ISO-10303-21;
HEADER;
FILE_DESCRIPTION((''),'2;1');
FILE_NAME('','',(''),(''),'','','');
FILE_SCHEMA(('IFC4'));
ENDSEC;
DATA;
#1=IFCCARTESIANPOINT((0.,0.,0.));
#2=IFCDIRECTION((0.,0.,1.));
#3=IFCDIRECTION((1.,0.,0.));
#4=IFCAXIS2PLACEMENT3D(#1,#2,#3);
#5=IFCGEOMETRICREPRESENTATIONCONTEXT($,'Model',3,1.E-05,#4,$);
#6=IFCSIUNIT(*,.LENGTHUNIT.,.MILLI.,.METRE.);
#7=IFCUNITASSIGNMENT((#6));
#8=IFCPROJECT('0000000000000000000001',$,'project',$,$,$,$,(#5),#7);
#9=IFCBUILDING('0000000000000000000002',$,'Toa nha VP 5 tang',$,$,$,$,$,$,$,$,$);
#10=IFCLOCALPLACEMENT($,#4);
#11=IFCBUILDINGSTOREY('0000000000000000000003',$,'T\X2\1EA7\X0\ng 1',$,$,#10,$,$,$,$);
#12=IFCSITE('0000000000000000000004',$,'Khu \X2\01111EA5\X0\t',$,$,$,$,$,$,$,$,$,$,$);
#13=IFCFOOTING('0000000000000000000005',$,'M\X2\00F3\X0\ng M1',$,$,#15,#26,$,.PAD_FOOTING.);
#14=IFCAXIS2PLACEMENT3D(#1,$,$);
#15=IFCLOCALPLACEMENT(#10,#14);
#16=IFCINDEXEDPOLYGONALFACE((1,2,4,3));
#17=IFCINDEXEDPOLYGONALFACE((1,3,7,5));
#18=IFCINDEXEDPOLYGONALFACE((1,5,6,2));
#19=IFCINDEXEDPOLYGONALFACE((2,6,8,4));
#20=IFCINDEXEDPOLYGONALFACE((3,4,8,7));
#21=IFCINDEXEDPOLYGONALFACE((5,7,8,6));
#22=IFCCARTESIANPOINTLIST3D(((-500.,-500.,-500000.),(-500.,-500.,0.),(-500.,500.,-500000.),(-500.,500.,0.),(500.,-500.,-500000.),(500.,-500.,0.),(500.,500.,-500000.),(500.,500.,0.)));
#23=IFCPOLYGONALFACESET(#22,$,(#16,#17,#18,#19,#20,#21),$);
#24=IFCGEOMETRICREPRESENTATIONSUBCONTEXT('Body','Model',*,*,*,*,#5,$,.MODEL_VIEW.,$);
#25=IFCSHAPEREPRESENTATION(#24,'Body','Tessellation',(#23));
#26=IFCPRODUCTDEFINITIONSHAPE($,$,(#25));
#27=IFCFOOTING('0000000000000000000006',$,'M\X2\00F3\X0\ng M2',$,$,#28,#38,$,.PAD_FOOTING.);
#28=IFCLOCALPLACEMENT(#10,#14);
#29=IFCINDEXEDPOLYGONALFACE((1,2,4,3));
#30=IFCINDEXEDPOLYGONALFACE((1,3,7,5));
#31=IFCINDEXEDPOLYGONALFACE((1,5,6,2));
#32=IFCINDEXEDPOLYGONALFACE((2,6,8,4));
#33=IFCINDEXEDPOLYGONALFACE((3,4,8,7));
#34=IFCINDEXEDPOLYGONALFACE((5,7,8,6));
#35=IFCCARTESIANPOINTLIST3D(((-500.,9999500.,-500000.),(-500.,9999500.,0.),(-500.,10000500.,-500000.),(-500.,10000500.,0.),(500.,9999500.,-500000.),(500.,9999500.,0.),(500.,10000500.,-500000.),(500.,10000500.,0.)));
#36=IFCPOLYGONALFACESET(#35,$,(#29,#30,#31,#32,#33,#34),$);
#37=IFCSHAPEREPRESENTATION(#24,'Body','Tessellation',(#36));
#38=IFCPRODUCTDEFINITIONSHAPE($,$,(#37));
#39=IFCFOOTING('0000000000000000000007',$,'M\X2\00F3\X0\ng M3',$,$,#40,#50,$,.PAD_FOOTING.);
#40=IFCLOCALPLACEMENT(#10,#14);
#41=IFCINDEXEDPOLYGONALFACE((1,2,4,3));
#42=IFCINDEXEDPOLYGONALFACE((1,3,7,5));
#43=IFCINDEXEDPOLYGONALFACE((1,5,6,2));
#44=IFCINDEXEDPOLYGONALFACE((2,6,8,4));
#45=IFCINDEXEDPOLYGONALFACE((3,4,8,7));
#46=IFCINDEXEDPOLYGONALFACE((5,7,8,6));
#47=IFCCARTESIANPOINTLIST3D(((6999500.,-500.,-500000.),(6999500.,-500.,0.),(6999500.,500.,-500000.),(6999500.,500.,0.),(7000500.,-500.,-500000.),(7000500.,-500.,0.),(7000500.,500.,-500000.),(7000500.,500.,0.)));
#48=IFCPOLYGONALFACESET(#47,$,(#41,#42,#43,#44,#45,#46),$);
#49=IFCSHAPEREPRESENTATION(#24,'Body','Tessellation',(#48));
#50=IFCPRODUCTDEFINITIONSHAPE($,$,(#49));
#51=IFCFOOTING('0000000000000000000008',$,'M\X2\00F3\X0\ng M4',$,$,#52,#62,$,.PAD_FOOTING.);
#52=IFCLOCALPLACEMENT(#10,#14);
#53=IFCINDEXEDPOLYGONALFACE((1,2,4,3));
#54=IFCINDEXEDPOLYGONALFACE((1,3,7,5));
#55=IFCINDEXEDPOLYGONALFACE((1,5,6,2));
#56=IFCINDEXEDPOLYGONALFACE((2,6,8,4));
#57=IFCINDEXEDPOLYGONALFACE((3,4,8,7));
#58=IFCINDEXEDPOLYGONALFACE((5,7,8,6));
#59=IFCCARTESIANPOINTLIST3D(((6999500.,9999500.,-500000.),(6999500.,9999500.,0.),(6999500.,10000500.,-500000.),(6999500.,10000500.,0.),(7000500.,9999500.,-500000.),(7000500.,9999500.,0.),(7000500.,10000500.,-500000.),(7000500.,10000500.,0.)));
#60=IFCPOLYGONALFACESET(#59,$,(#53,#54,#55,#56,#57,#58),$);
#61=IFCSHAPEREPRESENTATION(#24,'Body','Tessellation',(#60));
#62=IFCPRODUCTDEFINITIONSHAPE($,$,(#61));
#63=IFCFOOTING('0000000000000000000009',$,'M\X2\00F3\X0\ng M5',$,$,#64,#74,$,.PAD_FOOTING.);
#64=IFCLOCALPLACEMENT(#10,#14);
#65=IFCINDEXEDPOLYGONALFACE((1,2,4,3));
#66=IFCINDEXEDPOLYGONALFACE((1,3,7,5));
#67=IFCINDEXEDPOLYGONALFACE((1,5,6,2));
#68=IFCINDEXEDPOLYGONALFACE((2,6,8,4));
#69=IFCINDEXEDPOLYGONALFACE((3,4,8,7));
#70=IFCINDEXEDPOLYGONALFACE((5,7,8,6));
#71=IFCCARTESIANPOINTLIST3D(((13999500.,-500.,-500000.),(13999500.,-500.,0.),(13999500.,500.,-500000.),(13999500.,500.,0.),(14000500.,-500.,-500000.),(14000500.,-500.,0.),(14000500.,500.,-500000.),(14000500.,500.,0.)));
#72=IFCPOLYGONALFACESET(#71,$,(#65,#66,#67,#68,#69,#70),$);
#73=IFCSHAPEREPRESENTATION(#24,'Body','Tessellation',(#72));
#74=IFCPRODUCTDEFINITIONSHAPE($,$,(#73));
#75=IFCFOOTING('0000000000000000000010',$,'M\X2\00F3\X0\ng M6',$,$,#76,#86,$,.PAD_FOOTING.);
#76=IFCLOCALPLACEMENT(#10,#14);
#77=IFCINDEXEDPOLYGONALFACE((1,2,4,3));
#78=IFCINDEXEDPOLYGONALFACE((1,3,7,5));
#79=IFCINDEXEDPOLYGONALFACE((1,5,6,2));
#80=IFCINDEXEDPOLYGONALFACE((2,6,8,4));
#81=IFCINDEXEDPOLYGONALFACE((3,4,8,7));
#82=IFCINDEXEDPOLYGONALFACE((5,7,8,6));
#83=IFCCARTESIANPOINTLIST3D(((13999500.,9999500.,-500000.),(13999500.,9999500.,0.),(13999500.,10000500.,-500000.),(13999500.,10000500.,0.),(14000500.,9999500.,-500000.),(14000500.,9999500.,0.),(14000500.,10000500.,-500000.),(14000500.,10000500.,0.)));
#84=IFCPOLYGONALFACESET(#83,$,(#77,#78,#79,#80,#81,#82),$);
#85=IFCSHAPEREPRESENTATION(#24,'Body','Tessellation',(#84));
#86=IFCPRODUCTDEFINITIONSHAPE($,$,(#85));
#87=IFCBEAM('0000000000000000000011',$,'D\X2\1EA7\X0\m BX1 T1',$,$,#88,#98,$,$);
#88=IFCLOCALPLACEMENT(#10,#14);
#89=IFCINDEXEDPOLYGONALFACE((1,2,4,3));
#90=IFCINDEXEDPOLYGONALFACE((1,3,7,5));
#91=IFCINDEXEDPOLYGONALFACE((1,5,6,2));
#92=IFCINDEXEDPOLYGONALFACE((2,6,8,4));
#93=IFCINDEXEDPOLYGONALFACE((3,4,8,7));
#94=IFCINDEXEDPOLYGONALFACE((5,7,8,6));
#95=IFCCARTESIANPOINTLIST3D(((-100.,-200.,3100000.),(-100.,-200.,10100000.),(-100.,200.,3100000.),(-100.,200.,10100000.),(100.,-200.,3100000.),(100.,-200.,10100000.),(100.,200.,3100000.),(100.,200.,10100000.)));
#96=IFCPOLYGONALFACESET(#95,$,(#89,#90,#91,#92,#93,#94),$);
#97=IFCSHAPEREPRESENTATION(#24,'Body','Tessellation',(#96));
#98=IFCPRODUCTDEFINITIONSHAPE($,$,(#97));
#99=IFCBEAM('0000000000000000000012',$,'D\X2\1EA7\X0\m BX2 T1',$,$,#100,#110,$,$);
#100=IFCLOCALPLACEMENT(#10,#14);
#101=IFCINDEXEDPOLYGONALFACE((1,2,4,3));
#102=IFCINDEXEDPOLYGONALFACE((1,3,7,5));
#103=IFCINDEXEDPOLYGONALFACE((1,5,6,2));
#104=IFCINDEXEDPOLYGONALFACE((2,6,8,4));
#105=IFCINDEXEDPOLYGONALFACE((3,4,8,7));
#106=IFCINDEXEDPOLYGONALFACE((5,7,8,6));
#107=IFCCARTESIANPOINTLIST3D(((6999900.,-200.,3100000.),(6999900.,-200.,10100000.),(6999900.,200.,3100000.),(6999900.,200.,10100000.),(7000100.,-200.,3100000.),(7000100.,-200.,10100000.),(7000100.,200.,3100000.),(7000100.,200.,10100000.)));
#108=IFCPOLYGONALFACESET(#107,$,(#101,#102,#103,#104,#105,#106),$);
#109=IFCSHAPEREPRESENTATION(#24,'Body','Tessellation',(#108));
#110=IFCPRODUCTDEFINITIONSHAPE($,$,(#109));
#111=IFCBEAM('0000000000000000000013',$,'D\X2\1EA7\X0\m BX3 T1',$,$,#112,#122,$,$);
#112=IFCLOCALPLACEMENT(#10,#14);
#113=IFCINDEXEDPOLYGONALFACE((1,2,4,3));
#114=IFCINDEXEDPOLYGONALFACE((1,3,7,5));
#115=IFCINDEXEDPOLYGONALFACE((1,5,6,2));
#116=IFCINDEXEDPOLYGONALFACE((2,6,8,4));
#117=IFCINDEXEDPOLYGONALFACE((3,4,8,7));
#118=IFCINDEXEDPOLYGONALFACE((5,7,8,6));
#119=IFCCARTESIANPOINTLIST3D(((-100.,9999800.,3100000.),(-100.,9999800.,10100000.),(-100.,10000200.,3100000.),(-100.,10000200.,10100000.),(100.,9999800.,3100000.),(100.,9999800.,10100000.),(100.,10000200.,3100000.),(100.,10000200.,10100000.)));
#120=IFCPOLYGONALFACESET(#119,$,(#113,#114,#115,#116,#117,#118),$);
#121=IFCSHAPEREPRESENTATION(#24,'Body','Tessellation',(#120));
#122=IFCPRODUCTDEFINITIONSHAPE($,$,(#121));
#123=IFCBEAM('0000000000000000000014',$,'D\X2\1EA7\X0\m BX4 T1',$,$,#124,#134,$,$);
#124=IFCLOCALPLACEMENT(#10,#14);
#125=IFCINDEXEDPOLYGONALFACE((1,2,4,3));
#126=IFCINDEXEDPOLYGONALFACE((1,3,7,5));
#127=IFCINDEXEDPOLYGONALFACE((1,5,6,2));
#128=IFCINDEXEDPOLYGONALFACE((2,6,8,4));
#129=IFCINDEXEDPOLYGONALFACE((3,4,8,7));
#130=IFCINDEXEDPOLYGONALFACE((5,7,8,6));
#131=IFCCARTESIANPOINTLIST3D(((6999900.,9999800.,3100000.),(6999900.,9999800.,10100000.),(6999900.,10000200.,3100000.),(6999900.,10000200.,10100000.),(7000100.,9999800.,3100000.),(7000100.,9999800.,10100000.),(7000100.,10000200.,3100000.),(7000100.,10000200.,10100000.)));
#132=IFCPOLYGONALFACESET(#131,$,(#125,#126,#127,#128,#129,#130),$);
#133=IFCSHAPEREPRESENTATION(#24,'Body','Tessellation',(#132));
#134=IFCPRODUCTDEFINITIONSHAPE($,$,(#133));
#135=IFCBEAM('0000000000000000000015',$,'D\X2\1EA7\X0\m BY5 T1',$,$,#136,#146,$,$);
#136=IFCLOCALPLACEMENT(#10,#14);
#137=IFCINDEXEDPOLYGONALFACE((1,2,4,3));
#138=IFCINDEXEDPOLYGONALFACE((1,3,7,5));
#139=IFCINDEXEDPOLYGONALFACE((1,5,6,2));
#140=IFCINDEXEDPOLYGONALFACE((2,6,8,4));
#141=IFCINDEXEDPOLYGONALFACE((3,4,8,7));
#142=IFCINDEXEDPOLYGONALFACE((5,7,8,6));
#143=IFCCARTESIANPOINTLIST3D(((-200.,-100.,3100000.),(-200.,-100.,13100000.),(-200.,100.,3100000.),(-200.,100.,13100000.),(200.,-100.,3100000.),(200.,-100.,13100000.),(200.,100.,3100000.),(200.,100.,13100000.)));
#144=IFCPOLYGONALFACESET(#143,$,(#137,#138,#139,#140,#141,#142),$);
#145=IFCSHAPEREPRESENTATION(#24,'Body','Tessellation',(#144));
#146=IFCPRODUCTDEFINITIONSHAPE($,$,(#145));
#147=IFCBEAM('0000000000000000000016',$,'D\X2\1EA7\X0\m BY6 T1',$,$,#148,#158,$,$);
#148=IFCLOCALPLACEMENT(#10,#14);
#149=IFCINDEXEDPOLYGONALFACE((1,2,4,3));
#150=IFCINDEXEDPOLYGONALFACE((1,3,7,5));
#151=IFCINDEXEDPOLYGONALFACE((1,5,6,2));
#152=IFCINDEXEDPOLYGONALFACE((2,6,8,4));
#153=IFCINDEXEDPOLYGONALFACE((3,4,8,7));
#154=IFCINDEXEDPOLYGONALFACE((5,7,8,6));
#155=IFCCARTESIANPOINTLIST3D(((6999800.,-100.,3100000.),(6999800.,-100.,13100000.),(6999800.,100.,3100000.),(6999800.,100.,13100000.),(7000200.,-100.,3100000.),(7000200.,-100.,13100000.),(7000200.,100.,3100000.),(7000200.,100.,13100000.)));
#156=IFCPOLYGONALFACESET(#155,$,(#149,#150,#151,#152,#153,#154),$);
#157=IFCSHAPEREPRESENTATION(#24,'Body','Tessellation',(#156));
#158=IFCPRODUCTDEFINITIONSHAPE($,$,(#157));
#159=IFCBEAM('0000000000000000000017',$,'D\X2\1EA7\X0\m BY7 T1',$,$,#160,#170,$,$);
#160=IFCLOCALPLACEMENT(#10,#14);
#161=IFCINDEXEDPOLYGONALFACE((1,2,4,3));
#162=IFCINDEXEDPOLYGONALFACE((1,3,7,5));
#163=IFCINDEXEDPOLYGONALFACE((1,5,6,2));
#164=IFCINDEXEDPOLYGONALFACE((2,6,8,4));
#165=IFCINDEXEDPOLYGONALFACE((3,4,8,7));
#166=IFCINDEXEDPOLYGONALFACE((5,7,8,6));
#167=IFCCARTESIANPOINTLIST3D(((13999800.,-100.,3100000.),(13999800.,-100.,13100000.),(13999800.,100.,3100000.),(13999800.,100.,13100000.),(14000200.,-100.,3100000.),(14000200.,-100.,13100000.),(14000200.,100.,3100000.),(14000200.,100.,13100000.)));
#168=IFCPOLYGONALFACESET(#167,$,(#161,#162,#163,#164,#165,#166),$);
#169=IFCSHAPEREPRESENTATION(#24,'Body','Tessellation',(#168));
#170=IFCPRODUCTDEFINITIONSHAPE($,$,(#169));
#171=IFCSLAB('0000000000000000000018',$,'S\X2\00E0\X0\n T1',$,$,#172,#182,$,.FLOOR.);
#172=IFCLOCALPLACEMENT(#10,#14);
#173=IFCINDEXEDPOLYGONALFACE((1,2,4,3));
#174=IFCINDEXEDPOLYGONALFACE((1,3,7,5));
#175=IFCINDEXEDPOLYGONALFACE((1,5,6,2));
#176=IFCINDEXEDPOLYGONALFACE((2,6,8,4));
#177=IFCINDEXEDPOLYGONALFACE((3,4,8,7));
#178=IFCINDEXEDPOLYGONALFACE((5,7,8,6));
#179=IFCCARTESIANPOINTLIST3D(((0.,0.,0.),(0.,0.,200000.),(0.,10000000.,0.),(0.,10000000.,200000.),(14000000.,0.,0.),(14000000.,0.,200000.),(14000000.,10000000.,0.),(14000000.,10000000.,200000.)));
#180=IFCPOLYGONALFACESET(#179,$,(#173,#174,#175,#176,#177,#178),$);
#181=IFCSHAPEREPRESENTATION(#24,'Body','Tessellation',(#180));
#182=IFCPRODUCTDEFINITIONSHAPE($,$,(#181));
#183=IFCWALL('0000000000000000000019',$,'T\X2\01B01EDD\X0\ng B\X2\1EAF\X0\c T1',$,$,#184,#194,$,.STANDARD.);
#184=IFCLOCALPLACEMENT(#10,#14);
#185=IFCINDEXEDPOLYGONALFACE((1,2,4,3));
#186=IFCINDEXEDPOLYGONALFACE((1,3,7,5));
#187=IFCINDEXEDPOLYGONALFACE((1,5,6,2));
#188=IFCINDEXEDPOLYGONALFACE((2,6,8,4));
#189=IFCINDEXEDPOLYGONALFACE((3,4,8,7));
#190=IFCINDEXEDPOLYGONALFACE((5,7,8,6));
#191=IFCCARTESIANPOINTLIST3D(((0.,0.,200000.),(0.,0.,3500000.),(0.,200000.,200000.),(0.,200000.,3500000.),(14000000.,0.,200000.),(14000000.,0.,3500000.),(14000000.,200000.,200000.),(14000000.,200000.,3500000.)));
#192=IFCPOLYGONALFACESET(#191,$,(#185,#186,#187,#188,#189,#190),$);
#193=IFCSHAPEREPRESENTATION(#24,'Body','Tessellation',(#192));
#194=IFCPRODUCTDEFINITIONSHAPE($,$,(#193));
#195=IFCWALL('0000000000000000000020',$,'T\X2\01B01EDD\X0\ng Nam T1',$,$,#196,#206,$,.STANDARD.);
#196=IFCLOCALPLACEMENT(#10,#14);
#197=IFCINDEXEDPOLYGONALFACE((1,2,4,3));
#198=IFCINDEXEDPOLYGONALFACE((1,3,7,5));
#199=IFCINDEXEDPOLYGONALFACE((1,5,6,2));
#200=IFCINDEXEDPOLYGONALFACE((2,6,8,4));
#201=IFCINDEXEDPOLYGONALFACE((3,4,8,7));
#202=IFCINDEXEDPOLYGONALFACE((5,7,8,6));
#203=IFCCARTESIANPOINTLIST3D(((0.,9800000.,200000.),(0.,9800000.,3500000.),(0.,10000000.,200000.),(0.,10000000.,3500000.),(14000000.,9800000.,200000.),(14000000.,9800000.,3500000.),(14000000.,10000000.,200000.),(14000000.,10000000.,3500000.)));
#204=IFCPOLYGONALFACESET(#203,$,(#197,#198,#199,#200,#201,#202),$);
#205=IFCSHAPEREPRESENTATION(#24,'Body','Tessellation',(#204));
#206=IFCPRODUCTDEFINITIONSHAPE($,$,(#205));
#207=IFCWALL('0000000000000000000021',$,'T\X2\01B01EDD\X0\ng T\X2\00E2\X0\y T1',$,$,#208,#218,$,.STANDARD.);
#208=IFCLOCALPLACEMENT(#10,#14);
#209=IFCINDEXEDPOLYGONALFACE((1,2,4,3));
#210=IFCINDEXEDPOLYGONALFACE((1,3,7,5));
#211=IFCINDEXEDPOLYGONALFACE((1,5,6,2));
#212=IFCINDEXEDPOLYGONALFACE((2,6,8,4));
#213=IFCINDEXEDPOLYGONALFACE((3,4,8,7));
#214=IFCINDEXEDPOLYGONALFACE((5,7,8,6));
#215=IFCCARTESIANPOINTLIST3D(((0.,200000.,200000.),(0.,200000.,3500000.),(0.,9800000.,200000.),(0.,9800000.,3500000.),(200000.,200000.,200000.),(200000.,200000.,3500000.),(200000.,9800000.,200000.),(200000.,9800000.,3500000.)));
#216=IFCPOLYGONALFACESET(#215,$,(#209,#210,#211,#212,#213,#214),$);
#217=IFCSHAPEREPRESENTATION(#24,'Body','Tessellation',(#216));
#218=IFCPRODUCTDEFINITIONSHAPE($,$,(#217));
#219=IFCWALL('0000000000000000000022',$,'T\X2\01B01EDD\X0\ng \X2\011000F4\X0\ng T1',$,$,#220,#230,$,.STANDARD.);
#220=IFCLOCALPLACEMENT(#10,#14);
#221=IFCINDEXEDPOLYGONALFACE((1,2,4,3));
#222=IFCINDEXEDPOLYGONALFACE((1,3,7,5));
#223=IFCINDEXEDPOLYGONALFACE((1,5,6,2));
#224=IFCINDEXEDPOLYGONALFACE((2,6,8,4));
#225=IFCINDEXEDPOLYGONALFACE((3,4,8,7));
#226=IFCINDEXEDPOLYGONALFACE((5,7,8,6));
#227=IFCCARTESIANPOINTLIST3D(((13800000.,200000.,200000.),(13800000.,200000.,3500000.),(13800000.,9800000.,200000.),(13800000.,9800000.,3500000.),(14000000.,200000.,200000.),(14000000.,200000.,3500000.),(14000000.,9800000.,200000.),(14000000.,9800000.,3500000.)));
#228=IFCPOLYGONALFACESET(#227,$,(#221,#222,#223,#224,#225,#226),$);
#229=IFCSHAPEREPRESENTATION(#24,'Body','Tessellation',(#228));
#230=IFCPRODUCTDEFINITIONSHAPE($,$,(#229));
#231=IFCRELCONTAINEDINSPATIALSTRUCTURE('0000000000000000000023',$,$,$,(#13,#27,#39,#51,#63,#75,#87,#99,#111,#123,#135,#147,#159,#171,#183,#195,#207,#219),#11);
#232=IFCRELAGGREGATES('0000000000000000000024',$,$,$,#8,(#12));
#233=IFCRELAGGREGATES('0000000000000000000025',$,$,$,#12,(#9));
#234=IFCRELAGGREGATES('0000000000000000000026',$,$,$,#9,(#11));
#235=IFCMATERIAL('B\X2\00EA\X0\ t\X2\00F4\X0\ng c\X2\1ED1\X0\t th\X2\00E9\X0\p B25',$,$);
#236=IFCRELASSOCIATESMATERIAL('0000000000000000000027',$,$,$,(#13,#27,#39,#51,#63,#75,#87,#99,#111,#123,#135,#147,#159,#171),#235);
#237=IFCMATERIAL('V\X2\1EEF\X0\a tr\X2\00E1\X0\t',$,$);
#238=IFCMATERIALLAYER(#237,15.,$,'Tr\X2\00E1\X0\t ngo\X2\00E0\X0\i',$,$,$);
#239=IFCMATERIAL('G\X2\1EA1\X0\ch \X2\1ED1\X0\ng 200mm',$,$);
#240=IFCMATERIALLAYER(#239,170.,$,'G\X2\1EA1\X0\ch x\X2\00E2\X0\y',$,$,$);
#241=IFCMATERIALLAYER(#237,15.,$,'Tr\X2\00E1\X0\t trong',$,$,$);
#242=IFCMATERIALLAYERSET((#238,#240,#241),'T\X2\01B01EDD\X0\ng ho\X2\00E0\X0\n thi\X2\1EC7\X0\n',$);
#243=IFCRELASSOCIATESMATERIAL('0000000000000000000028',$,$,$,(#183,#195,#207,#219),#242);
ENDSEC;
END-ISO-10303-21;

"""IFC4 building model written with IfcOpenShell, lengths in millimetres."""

from ifc_helpers import new_model, entity, si_unit, frame, origin_with_axes, place, context, subcontext, project, spatial, indexed_curve, outline, extrude, material, layer, layer_set, layer_usage, element, save


model = new_model("IFC4")

# Units and contexts
model_context = context("Model", 3, precision=1e-05, world=origin_with_axes())
body_context = subcontext(model_context, "Body", "Model", "MODEL_VIEW")
ifc_project = project(units=[si_unit("LENGTHUNIT", "METRE", prefix="MILLI")], contexts=[model_context])

# Site, building, storey
site = spatial("IfcSite", under=ifc_project, Name="Khu đất")
building = spatial("IfcBuilding", under=site, Name="Toa nha VP 5 tang")
storey_placement = place(None, origin_with_axes())
storey = spatial("IfcBuildingStorey", under=building, at=storey_placement, Name="Tầng 1")

# Footings
ifc_material_1 = material(Name="Bê tông cốt thép B25")
for number, where, z_axis, x_axis, name in (
    (1, (0.0, 0.0, -500000.0), (0.0, 0.0, 1.0), (1.0, 0.0, 0.0), "Móng M1"),
    (2, (0.0, 10000000.0, -500000.0), (0.0, 0.0, 1.0), (1.0, 0.0, 0.0), "Móng M2"),
    (3, (7000000.0, 0.0, -500000.0), (0.0, 0.0, 1.0), (1.0, 0.0, 0.0), "Móng M3"),
    (4, (7000000.0, 10000000.0, -500000.0), (0.0, 0.0, 1.0), (1.0, 0.0, 0.0), "Móng M4"),
    (5, (14000000.0, 0.0, -500000.0), (0.0, 0.0, 1.0), (1.0, 0.0, 0.0), "Móng M5"),
    (6, (14000000.0, 10000000.0, -500000.0), (0.0, 0.0, 1.0), (1.0, 0.0, 0.0), "Móng M6"),
):
    element("IfcFooting", number, at=place(storey_placement, frame(where, z_axis=z_axis, x_axis=x_axis)), inside=storey, material=ifc_material_1, Name=name, PredefinedType="PAD_FOOTING", context=body_context, shape_type="SweptSolid", body=[
        extrude(entity("IfcRectangleProfileDef", None, None, None, 1000.0, 1000.0), origin_with_axes(), (0.0, 0.0, 1.0), 500000.0),
    ])

# Beams
for number, where, z_axis, x_axis, name in (
    (7, (0.0, 0.0, 3100000.0), (0.0, 0.0, 1.0), (1.0, 0.0, 0.0), "Dầm BX1 T1"),
    (8, (7000000.0, 0.0, 3100000.0), (0.0, 0.0, 1.0), (1.0, 0.0, 0.0), "Dầm BX2 T1"),
    (9, (0.0, 10000000.0, 3100000.0), (0.0, 0.0, 1.0), (1.0, 0.0, 0.0), "Dầm BX3 T1"),
    (10, (7000000.0, 10000000.0, 3100000.0), (0.0, 0.0, 1.0), (1.0, 0.0, 0.0), "Dầm BX4 T1"),
):
    element("IfcBeam", number, at=place(storey_placement, frame(where, z_axis=z_axis, x_axis=x_axis)), inside=storey, material=ifc_material_1, Name=name, context=body_context, shape_type="SweptSolid", body=[
        extrude(entity("IfcRectangleProfileDef", None, None, None, 200.0, 400.0), origin_with_axes(), (0.0, 0.0, 1.0), 7000000.0),
    ])
for number, where, z_axis, x_axis, name in (
    (11, (0.0, 0.0, 3100000.0), (0.0, 0.0, 1.0), (0.0, 1.0, 0.0), "Dầm BY5 T1"),
    (12, (7000000.0, 0.0, 3100000.0), (0.0, 0.0, 1.0), (0.0, 1.0, 0.0), "Dầm BY6 T1"),
    (13, (14000000.0, 0.0, 3100000.0), (0.0, 0.0, 1.0), (0.0, 1.0, 0.0), "Dầm BY7 T1"),
):
    element("IfcBeam", number, at=place(storey_placement, frame(where, z_axis=z_axis, x_axis=x_axis)), inside=storey, material=ifc_material_1, Name=name, context=body_context, shape_type="SweptSolid", body=[
        extrude(entity("IfcRectangleProfileDef", None, None, None, 200.0, 400.0), origin_with_axes(), (0.0, 0.0, 1.0), 10000000.0),
    ])

# Slab
slab_placement = place(storey_placement, origin_with_axes())
element("IfcSlab", 14, at=slab_placement, inside=storey, material=ifc_material_1, Name="Sàn T1", PredefinedType="FLOOR", context=body_context, shape_type="SweptSolid", body=[
    extrude(outline(indexed_curve([(0.0, 0.0), (14000000.0, 0.0), (14000000.0, 10000000.0), (0.0, 10000000.0), (0.0, 0.0)])), None, (0.0, 0.0, 1.0), 200000.0),
])

# Walls
ifc_material_2 = material(Name="Vữa trát")
ifc_layer_1 = layer(ifc_material_2, 15.0, Name="Trát ngoài")
ifc_material_3 = material(Name="Gạch ống 200mm")
ifc_layer_2 = layer(ifc_material_3, 170.0, Name="Gạch xây")
ifc_layer_3 = layer(ifc_material_2, 15.0, Name="Trát trong")
ifc_layer_set = layer_set([ifc_layer_1, ifc_layer_2, ifc_layer_3], Name="Tường hoàn thiện")
ifc_layer_usage_1 = layer_usage(ifc_layer_set, "AXIS2", "POSITIVE", 0.0)
wall_1_placement = place(storey_placement, frame((0.0, 0.0, 200000.0), z_axis=(0.0, 0.0, 1.0), x_axis=(1.0, 0.0, 0.0)))
element("IfcWall", 15, at=wall_1_placement, inside=storey, material=ifc_layer_usage_1, Name="Tường Bắc T1", PredefinedType="STANDARD", context=body_context, shape_type="SweptSolid", body=[
    extrude(outline(indexed_curve([(0.0, 0.0), (0.0, 200000.0), (14000000.0, 200000.0), (14000000.0, 0.0), (0.0, 0.0)], self_intersect=False)), origin_with_axes(), (0.0, 0.0, 1.0), 3300000.0),
])
ifc_layer_usage_2 = layer_usage(ifc_layer_set, "AXIS2", "POSITIVE", 0.0)
wall_2_placement = place(storey_placement, frame((0.0, 9800000.0, 200000.0), z_axis=(0.0, 0.0, 1.0), x_axis=(1.0, 0.0, 0.0)))
element("IfcWall", 16, at=wall_2_placement, inside=storey, material=ifc_layer_usage_2, Name="Tường Nam T1", PredefinedType="STANDARD", context=body_context, shape_type="SweptSolid", body=[
    extrude(outline(indexed_curve([(0.0, 0.0), (0.0, 200000.0), (14000000.0, 200000.0), (14000000.0, 0.0), (0.0, 0.0)], self_intersect=False)), origin_with_axes(), (0.0, 0.0, 1.0), 3300000.0),
])
ifc_layer_usage_3 = layer_usage(ifc_layer_set, "AXIS2", "POSITIVE", 0.0)
wall_3_placement = place(storey_placement, frame((0.0, 200000.0, 200000.0), z_axis=(0.0, 0.0, 1.0), x_axis=(1.0, 0.0, 0.0)))
element("IfcWall", 17, at=wall_3_placement, inside=storey, material=ifc_layer_usage_3, Name="Tường Tây T1", PredefinedType="STANDARD", context=body_context, shape_type="SweptSolid", body=[
    extrude(outline(indexed_curve([(0.0, 0.0), (0.0, 9600000.0), (200000.0, 9600000.0), (200000.0, 0.0), (0.0, 0.0)], self_intersect=False)), origin_with_axes(), (0.0, 0.0, 1.0), 3300000.0),
])
ifc_layer_usage_4 = layer_usage(ifc_layer_set, "AXIS2", "POSITIVE", 0.0)
wall_4_placement = place(storey_placement, frame((13800000.0, 200000.0, 200000.0), z_axis=(0.0, 0.0, 1.0), x_axis=(1.0, 0.0, 0.0)))
element("IfcWall", 18, at=wall_4_placement, inside=storey, material=ifc_layer_usage_4, Name="Tường Đông T1", PredefinedType="STANDARD", context=body_context, shape_type="SweptSolid", body=[
    extrude(outline(indexed_curve([(0.0, 0.0), (0.0, 9600000.0), (200000.0, 9600000.0), (200000.0, 0.0), (0.0, 0.0)], self_intersect=False)), origin_with_axes(), (0.0, 0.0, 1.0), 3300000.0),
])

save(model, "model.ifc")
